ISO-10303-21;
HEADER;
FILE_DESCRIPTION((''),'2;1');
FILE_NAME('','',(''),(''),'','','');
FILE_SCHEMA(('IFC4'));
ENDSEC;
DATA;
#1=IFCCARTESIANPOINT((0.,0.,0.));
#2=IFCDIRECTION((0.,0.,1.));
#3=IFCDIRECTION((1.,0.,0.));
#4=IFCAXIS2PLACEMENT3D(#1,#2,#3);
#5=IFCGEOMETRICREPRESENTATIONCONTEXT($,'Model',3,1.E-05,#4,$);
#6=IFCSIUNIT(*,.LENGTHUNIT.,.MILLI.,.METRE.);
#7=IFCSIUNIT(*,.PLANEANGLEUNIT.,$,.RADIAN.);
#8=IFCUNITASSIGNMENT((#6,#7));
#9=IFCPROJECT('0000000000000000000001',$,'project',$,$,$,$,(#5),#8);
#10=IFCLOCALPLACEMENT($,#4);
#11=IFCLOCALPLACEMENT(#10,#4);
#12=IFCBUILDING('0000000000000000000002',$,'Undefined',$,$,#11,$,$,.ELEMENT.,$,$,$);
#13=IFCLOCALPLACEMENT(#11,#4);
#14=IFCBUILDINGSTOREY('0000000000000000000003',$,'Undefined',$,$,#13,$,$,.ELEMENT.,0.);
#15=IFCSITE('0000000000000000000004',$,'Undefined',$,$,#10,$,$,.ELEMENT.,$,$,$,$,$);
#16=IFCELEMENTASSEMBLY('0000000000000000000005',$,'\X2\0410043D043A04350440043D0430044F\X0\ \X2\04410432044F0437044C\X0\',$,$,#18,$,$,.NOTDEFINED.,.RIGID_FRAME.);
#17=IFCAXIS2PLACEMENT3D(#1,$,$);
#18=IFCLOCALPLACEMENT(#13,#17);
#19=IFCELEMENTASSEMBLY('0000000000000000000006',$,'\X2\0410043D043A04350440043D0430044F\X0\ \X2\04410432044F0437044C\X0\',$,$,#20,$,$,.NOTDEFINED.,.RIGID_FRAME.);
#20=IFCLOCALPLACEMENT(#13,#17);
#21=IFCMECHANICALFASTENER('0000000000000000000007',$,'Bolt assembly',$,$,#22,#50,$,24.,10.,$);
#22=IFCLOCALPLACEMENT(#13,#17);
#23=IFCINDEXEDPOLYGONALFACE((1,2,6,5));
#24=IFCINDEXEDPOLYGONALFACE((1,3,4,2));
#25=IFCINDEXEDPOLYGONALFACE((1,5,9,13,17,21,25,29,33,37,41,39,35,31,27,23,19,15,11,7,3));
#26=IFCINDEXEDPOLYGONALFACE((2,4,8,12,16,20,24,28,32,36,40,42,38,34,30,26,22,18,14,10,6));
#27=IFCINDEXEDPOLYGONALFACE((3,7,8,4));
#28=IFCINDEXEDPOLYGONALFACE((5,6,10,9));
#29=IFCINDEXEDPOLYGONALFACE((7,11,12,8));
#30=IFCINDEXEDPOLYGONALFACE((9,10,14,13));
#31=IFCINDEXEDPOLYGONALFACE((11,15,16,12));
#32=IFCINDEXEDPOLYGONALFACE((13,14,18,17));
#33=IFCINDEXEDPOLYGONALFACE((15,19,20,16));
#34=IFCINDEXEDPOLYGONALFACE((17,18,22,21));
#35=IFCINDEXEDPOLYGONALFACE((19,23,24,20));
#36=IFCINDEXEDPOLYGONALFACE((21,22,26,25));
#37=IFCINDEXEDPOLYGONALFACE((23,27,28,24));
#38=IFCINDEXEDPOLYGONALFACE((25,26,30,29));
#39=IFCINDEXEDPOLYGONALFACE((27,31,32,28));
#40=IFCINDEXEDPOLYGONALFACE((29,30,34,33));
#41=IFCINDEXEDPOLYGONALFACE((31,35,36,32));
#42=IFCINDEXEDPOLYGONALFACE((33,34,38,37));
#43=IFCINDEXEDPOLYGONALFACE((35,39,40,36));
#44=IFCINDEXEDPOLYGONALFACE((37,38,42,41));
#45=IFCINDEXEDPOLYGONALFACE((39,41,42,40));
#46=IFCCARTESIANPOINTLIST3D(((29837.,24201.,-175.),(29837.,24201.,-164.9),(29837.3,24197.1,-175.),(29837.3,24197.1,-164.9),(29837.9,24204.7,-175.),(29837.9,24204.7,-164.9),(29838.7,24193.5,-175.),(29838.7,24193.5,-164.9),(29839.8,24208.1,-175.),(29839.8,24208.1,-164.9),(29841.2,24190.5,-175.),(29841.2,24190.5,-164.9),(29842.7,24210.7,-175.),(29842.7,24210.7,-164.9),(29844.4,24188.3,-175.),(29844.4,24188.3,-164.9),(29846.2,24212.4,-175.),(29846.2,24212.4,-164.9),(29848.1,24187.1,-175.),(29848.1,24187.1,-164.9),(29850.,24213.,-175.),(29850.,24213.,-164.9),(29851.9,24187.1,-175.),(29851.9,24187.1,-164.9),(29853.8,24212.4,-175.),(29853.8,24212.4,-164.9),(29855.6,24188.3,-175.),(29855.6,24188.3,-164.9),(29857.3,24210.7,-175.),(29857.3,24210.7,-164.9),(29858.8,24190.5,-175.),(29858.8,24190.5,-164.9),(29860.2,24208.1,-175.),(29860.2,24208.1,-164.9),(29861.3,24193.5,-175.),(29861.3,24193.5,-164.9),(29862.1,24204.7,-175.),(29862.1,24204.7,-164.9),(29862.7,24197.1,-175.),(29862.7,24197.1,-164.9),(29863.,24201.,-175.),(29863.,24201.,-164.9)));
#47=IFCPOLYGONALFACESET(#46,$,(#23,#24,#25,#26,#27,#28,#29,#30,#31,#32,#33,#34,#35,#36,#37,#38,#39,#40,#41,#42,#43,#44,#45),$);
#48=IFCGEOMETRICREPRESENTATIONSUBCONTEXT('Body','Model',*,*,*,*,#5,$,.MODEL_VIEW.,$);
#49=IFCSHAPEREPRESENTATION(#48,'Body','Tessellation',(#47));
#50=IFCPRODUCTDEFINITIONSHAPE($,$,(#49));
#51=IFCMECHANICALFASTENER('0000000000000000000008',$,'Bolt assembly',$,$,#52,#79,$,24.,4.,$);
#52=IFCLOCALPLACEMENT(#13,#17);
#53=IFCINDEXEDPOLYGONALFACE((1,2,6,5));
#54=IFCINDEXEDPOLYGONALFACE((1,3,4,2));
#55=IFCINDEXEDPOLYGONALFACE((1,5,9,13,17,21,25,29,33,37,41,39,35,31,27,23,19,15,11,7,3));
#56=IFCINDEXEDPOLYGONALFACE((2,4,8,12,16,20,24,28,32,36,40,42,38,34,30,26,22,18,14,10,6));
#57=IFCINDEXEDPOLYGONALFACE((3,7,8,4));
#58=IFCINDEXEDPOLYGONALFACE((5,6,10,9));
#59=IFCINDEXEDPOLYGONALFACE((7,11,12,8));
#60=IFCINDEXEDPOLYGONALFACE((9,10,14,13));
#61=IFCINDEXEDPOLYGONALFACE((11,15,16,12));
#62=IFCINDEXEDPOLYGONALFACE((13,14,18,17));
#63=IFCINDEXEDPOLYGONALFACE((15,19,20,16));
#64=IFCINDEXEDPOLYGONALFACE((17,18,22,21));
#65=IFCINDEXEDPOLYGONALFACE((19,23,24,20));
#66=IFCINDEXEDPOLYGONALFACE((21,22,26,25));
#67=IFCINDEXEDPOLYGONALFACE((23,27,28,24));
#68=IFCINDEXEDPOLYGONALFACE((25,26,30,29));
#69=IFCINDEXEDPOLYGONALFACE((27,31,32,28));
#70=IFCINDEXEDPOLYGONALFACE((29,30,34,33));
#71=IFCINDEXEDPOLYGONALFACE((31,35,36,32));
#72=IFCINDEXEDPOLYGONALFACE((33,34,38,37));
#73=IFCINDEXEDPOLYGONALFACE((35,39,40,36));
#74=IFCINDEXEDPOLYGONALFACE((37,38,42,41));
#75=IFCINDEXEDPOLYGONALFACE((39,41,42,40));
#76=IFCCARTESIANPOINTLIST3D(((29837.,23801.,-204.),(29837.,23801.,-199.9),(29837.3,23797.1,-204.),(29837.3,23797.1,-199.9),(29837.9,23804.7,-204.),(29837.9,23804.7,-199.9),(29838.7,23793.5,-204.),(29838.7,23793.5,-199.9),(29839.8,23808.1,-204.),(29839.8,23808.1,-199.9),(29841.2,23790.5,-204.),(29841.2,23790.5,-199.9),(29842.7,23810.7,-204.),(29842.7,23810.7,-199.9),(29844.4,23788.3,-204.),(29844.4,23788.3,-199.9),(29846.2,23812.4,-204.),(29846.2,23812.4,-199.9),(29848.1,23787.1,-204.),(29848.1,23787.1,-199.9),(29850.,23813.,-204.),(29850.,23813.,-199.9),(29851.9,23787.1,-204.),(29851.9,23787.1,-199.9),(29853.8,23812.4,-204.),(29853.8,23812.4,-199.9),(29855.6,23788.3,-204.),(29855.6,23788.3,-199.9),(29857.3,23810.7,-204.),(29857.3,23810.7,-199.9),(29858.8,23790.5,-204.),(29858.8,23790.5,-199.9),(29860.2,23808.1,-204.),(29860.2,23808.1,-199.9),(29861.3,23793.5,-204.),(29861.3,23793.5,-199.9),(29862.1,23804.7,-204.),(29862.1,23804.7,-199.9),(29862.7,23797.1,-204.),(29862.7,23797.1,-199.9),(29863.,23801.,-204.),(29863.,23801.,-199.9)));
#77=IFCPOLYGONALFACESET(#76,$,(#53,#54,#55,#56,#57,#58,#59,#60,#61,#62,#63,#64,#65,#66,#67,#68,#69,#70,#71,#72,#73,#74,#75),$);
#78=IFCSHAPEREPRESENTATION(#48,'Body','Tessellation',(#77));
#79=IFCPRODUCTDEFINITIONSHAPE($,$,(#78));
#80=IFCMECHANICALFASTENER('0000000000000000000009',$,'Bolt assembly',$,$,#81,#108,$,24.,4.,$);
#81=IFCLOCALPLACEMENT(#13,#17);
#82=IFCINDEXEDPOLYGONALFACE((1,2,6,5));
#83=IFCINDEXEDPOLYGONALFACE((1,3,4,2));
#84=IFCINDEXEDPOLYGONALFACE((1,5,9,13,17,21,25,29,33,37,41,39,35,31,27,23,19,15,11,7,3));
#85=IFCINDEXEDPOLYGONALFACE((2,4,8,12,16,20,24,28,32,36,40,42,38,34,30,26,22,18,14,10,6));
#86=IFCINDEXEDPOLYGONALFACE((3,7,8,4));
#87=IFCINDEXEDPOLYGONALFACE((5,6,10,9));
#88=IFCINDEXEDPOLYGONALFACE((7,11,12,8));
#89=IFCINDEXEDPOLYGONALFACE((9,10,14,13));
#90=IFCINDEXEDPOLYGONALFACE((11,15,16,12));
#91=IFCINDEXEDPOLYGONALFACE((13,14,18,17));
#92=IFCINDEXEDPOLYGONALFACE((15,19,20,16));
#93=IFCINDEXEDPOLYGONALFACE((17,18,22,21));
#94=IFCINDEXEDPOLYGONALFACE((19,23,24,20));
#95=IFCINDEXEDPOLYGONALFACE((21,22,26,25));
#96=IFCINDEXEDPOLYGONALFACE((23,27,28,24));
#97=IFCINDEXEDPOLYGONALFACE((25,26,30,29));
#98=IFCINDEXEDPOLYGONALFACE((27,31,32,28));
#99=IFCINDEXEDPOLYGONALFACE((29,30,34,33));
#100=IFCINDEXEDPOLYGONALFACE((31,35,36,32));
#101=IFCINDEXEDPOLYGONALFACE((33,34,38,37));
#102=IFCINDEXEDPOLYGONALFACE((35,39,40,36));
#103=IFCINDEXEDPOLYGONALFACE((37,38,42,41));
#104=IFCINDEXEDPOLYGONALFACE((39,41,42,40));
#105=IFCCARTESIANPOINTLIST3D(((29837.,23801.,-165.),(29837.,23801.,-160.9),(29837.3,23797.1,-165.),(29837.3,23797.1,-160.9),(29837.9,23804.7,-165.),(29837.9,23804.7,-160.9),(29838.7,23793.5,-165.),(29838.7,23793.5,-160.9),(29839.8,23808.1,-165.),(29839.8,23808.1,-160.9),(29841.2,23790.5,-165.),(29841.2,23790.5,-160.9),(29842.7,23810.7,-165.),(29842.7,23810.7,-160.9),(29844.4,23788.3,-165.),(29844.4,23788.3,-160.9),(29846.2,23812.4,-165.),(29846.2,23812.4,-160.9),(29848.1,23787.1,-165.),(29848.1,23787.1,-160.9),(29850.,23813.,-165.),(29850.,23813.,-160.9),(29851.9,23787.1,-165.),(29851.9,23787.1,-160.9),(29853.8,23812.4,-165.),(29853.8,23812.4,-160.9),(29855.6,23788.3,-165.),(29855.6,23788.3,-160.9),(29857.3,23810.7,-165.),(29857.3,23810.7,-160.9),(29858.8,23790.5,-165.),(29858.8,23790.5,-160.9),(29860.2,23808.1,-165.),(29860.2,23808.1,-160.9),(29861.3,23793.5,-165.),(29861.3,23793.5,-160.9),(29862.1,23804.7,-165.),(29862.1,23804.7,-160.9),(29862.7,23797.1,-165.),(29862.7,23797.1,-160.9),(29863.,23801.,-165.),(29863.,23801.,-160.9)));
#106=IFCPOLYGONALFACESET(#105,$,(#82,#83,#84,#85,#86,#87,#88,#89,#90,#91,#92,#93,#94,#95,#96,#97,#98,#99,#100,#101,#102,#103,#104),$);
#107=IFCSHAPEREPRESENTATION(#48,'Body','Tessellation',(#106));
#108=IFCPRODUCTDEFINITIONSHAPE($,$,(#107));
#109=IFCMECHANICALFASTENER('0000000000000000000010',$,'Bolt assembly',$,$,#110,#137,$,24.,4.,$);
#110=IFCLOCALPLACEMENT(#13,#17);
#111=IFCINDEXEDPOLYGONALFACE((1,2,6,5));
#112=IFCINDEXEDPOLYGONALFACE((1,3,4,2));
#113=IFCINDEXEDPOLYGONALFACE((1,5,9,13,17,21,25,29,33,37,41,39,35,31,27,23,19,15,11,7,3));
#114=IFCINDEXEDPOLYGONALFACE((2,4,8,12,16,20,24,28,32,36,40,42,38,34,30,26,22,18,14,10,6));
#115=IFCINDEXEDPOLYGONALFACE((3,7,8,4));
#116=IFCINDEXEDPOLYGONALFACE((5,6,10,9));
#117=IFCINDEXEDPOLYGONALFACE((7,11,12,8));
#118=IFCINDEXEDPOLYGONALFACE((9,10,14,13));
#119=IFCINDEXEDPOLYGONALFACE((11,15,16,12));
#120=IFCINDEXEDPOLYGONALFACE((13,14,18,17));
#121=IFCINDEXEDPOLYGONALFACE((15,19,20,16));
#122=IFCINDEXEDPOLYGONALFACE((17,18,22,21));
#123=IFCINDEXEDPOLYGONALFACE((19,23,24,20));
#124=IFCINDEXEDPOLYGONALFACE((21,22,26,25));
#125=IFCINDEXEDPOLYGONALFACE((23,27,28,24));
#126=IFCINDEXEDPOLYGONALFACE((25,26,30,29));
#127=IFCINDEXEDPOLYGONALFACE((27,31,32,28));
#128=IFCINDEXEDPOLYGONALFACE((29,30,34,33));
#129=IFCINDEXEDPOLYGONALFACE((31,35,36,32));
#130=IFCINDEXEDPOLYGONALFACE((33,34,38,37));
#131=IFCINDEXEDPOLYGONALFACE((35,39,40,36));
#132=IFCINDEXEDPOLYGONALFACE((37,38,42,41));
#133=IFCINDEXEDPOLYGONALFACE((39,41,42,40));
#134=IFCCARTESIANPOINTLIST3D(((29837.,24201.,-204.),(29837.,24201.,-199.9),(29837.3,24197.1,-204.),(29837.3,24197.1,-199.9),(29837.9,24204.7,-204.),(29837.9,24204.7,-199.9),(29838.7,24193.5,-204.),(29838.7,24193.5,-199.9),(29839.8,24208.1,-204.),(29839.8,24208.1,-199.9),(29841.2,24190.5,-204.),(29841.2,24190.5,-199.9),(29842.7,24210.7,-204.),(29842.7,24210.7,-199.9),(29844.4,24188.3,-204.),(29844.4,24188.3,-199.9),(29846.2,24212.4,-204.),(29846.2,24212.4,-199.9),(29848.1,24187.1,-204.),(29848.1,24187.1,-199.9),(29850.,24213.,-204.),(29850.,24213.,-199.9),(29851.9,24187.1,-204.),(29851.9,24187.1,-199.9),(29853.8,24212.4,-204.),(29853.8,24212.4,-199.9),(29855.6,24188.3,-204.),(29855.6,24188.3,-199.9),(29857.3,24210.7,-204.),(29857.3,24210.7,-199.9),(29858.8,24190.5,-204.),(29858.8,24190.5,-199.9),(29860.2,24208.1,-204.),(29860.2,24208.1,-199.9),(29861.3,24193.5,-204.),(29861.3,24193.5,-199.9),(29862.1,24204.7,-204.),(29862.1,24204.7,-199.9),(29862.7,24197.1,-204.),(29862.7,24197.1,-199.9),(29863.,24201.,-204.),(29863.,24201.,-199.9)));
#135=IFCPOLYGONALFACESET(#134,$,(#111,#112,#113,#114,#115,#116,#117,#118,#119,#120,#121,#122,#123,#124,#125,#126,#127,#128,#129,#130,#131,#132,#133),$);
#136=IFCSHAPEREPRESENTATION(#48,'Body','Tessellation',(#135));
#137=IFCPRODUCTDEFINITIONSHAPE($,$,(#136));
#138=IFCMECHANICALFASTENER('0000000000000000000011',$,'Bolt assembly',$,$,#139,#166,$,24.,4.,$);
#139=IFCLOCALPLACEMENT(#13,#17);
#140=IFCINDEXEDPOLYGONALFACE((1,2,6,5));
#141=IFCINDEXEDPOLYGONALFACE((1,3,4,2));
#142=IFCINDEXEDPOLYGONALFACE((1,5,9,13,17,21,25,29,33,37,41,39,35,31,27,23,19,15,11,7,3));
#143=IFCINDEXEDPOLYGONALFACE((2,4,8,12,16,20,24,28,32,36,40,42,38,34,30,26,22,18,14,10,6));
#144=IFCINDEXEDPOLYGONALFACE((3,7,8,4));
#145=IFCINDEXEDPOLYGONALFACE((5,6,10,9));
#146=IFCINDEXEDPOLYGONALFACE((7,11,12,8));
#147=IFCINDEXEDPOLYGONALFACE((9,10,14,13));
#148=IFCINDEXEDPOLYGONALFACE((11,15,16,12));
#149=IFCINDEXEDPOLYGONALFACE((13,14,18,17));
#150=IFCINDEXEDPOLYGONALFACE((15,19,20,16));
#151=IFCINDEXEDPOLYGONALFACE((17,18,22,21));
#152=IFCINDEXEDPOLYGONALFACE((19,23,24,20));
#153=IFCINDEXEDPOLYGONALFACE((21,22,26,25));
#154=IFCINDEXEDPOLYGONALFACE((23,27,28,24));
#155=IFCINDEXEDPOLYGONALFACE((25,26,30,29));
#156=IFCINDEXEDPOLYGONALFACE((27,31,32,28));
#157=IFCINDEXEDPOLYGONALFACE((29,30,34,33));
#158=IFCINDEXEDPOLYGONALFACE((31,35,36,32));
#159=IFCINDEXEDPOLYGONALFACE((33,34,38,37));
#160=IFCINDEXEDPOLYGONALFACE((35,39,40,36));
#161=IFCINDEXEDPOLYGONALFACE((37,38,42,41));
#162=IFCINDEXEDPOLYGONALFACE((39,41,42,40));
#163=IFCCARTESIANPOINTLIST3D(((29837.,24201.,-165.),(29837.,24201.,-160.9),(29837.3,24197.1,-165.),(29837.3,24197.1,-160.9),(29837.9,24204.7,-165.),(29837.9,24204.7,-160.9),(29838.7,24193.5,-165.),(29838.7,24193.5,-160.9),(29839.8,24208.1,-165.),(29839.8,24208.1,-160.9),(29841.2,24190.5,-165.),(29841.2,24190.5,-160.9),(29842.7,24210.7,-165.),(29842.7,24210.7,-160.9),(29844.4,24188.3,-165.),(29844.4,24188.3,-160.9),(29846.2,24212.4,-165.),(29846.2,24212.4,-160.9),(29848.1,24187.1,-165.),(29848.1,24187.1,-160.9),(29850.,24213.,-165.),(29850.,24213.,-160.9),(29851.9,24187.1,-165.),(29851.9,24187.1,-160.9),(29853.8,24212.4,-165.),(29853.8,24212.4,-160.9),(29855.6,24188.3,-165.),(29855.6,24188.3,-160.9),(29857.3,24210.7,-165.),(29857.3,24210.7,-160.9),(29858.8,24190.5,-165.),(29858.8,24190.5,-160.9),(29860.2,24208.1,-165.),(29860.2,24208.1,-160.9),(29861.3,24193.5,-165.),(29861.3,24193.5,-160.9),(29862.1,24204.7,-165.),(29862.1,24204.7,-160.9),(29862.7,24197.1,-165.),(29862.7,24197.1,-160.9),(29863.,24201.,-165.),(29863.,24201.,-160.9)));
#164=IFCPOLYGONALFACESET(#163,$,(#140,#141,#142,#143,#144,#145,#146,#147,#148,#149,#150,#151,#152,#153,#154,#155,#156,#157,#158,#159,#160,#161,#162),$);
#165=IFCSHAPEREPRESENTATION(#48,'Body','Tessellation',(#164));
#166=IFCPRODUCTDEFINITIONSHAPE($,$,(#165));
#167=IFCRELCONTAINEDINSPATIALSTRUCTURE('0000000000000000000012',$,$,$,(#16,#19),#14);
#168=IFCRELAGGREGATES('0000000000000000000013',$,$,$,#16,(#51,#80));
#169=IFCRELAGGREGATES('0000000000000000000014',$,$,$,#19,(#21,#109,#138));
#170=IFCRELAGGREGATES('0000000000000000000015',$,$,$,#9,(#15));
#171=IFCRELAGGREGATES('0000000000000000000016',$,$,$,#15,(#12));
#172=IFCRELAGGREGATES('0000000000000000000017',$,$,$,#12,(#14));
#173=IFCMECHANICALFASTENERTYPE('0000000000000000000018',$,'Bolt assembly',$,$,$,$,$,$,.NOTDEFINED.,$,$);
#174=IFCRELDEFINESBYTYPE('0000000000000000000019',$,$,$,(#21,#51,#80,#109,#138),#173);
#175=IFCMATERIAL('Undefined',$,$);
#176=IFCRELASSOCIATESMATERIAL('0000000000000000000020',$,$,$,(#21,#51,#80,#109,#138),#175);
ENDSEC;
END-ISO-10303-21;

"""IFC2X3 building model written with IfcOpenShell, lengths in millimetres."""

from ifc_helpers import new_model, si_unit, frame, origin_with_axes, origin_2d_with_axis, place, context, subcontext, project, spatial, circle, extrude, source, transform, mapped, material, type_object, element, aggregate, save


model = new_model("IFC2X3")

# Units and contexts
model_context = context("Model", 3, precision=1e-05, world=origin_with_axes())
body_context = subcontext(model_context, "Body", "Model", "MODEL_VIEW")
ifc_project = project(units=[si_unit("LENGTHUNIT", "METRE", prefix="MILLI"), si_unit("PLANEANGLEUNIT", "RADIAN")], contexts=[model_context])

# Site, building, storey
site_placement = place(None, origin_with_axes())
site = spatial("IfcSite", under=ifc_project, at=site_placement, Name="Undefined", CompositionType="ELEMENT")
building_placement = place(site_placement, origin_with_axes())
building = spatial("IfcBuilding", under=site, at=building_placement, Name="Undefined", CompositionType="ELEMENT")
storey_placement = place(building_placement, origin_with_axes())
storey = spatial("IfcBuildingStorey", under=building, at=storey_placement, Name="Undefined", CompositionType="ELEMENT", Elevation=0.0)

# Element assemblies
assembly_1_placement = place(storey_placement, origin_with_axes())
assembly_1 = element("IfcElementAssembly", 1, at=assembly_1_placement, inside=storey, Name="Анкерная связь", AssemblyPlace="NOTDEFINED", PredefinedType="RIGID_FRAME")
assembly_2_placement = place(storey_placement, origin_with_axes())
assembly_2 = element("IfcElementAssembly", 2, at=assembly_2_placement, inside=storey, Name="Анкерная связь", AssemblyPlace="NOTDEFINED", PredefinedType="RIGID_FRAME")

# Mechanical fasteners
ifc_material_1 = material(Name="Undefined")
mechanical_fastener_type = type_object("IfcMechanicalFastenerType", Name="Bolt assembly")
shared_shape_1 = source(origin_with_axes(), body_context, "Body", "SweptSolid", [
    extrude(circle(Radius=13.0, at=origin_2d_with_axis()), frame((0.0, 0.0, 0.0), z_axis=(0.0, 1.0, 0.0), x_axis=(1.0, 0.0, 0.0)), (0.0, 0.0, 1.0), 10.1),
])
mechanical_fastener_1_placement = place(assembly_2_placement, frame((29850.0, 24200.0, -175.0), z_axis=(1.0, 0.0, 0.0), x_axis=(0.0, 1.0, 0.0)))
mechanical_fastener_1 = element("IfcMechanicalFastener", 3, at=mechanical_fastener_1_placement, type_object=mechanical_fastener_type, material=ifc_material_1, Name="Bolt assembly", NominalDiameter=24.0, NominalLength=10.0, context=body_context, shape_type="MappedRepresentation", body=[
    mapped(shared_shape_1, transform((0.0, 0.0, 0.0))),
])
shared_shape_2 = source(origin_with_axes(), body_context, "Body", "SweptSolid", [
    extrude(circle(Radius=13.0, at=origin_2d_with_axis()), frame((0.0, -4.0, 0.0), z_axis=(0.0, 1.0, 0.0), x_axis=(1.0, 0.0, 0.0)), (0.0, 0.0, 1.0), 4.1),
])
mechanical_fastener_2_placement = place(assembly_1_placement, frame((29850.0, 23800.0, -200.0), z_axis=(1.0, 0.0, 0.0), x_axis=(0.0, 1.0, 0.0)))
mechanical_fastener_2 = element("IfcMechanicalFastener", 4, at=mechanical_fastener_2_placement, type_object=mechanical_fastener_type, material=ifc_material_1, Name="Bolt assembly", NominalDiameter=24.0, NominalLength=4.0, context=body_context, shape_type="MappedRepresentation", body=[
    mapped(shared_shape_2, transform((0.0, 0.0, 0.0))),
])
mechanical_fastener_3_placement = place(assembly_1_placement, frame((29850.0, 23800.0, -161.0), z_axis=(1.0, 0.0, 0.0), x_axis=(0.0, 1.0, 0.0)))
mechanical_fastener_3 = element("IfcMechanicalFastener", 5, at=mechanical_fastener_3_placement, type_object=mechanical_fastener_type, material=ifc_material_1, Name="Bolt assembly", NominalDiameter=24.0, NominalLength=4.0, context=body_context, shape_type="MappedRepresentation", body=[
    mapped(shared_shape_2, transform((0.0, 0.0, 0.0))),
])
aggregate(assembly_1, [mechanical_fastener_2, mechanical_fastener_3])
mechanical_fastener_4_placement = place(assembly_2_placement, frame((29850.0, 24200.0, -200.0), z_axis=(1.0, 0.0, 0.0), x_axis=(0.0, 1.0, 0.0)))
mechanical_fastener_4 = element("IfcMechanicalFastener", 6, at=mechanical_fastener_4_placement, type_object=mechanical_fastener_type, material=ifc_material_1, Name="Bolt assembly", NominalDiameter=24.0, NominalLength=4.0, context=body_context, shape_type="MappedRepresentation", body=[
    mapped(shared_shape_2, transform((0.0, 0.0, 0.0))),
])
mechanical_fastener_5_placement = place(assembly_2_placement, frame((29850.0, 24200.0, -161.0), z_axis=(1.0, 0.0, 0.0), x_axis=(0.0, 1.0, 0.0)))
mechanical_fastener_5 = element("IfcMechanicalFastener", 7, at=mechanical_fastener_5_placement, type_object=mechanical_fastener_type, material=ifc_material_1, Name="Bolt assembly", NominalDiameter=24.0, NominalLength=4.0, context=body_context, shape_type="MappedRepresentation", body=[
    mapped(shared_shape_2, transform((0.0, 0.0, 0.0))),
])
aggregate(assembly_2, [mechanical_fastener_1, mechanical_fastener_4, mechanical_fastener_5])

save(model, "model.ifc")
